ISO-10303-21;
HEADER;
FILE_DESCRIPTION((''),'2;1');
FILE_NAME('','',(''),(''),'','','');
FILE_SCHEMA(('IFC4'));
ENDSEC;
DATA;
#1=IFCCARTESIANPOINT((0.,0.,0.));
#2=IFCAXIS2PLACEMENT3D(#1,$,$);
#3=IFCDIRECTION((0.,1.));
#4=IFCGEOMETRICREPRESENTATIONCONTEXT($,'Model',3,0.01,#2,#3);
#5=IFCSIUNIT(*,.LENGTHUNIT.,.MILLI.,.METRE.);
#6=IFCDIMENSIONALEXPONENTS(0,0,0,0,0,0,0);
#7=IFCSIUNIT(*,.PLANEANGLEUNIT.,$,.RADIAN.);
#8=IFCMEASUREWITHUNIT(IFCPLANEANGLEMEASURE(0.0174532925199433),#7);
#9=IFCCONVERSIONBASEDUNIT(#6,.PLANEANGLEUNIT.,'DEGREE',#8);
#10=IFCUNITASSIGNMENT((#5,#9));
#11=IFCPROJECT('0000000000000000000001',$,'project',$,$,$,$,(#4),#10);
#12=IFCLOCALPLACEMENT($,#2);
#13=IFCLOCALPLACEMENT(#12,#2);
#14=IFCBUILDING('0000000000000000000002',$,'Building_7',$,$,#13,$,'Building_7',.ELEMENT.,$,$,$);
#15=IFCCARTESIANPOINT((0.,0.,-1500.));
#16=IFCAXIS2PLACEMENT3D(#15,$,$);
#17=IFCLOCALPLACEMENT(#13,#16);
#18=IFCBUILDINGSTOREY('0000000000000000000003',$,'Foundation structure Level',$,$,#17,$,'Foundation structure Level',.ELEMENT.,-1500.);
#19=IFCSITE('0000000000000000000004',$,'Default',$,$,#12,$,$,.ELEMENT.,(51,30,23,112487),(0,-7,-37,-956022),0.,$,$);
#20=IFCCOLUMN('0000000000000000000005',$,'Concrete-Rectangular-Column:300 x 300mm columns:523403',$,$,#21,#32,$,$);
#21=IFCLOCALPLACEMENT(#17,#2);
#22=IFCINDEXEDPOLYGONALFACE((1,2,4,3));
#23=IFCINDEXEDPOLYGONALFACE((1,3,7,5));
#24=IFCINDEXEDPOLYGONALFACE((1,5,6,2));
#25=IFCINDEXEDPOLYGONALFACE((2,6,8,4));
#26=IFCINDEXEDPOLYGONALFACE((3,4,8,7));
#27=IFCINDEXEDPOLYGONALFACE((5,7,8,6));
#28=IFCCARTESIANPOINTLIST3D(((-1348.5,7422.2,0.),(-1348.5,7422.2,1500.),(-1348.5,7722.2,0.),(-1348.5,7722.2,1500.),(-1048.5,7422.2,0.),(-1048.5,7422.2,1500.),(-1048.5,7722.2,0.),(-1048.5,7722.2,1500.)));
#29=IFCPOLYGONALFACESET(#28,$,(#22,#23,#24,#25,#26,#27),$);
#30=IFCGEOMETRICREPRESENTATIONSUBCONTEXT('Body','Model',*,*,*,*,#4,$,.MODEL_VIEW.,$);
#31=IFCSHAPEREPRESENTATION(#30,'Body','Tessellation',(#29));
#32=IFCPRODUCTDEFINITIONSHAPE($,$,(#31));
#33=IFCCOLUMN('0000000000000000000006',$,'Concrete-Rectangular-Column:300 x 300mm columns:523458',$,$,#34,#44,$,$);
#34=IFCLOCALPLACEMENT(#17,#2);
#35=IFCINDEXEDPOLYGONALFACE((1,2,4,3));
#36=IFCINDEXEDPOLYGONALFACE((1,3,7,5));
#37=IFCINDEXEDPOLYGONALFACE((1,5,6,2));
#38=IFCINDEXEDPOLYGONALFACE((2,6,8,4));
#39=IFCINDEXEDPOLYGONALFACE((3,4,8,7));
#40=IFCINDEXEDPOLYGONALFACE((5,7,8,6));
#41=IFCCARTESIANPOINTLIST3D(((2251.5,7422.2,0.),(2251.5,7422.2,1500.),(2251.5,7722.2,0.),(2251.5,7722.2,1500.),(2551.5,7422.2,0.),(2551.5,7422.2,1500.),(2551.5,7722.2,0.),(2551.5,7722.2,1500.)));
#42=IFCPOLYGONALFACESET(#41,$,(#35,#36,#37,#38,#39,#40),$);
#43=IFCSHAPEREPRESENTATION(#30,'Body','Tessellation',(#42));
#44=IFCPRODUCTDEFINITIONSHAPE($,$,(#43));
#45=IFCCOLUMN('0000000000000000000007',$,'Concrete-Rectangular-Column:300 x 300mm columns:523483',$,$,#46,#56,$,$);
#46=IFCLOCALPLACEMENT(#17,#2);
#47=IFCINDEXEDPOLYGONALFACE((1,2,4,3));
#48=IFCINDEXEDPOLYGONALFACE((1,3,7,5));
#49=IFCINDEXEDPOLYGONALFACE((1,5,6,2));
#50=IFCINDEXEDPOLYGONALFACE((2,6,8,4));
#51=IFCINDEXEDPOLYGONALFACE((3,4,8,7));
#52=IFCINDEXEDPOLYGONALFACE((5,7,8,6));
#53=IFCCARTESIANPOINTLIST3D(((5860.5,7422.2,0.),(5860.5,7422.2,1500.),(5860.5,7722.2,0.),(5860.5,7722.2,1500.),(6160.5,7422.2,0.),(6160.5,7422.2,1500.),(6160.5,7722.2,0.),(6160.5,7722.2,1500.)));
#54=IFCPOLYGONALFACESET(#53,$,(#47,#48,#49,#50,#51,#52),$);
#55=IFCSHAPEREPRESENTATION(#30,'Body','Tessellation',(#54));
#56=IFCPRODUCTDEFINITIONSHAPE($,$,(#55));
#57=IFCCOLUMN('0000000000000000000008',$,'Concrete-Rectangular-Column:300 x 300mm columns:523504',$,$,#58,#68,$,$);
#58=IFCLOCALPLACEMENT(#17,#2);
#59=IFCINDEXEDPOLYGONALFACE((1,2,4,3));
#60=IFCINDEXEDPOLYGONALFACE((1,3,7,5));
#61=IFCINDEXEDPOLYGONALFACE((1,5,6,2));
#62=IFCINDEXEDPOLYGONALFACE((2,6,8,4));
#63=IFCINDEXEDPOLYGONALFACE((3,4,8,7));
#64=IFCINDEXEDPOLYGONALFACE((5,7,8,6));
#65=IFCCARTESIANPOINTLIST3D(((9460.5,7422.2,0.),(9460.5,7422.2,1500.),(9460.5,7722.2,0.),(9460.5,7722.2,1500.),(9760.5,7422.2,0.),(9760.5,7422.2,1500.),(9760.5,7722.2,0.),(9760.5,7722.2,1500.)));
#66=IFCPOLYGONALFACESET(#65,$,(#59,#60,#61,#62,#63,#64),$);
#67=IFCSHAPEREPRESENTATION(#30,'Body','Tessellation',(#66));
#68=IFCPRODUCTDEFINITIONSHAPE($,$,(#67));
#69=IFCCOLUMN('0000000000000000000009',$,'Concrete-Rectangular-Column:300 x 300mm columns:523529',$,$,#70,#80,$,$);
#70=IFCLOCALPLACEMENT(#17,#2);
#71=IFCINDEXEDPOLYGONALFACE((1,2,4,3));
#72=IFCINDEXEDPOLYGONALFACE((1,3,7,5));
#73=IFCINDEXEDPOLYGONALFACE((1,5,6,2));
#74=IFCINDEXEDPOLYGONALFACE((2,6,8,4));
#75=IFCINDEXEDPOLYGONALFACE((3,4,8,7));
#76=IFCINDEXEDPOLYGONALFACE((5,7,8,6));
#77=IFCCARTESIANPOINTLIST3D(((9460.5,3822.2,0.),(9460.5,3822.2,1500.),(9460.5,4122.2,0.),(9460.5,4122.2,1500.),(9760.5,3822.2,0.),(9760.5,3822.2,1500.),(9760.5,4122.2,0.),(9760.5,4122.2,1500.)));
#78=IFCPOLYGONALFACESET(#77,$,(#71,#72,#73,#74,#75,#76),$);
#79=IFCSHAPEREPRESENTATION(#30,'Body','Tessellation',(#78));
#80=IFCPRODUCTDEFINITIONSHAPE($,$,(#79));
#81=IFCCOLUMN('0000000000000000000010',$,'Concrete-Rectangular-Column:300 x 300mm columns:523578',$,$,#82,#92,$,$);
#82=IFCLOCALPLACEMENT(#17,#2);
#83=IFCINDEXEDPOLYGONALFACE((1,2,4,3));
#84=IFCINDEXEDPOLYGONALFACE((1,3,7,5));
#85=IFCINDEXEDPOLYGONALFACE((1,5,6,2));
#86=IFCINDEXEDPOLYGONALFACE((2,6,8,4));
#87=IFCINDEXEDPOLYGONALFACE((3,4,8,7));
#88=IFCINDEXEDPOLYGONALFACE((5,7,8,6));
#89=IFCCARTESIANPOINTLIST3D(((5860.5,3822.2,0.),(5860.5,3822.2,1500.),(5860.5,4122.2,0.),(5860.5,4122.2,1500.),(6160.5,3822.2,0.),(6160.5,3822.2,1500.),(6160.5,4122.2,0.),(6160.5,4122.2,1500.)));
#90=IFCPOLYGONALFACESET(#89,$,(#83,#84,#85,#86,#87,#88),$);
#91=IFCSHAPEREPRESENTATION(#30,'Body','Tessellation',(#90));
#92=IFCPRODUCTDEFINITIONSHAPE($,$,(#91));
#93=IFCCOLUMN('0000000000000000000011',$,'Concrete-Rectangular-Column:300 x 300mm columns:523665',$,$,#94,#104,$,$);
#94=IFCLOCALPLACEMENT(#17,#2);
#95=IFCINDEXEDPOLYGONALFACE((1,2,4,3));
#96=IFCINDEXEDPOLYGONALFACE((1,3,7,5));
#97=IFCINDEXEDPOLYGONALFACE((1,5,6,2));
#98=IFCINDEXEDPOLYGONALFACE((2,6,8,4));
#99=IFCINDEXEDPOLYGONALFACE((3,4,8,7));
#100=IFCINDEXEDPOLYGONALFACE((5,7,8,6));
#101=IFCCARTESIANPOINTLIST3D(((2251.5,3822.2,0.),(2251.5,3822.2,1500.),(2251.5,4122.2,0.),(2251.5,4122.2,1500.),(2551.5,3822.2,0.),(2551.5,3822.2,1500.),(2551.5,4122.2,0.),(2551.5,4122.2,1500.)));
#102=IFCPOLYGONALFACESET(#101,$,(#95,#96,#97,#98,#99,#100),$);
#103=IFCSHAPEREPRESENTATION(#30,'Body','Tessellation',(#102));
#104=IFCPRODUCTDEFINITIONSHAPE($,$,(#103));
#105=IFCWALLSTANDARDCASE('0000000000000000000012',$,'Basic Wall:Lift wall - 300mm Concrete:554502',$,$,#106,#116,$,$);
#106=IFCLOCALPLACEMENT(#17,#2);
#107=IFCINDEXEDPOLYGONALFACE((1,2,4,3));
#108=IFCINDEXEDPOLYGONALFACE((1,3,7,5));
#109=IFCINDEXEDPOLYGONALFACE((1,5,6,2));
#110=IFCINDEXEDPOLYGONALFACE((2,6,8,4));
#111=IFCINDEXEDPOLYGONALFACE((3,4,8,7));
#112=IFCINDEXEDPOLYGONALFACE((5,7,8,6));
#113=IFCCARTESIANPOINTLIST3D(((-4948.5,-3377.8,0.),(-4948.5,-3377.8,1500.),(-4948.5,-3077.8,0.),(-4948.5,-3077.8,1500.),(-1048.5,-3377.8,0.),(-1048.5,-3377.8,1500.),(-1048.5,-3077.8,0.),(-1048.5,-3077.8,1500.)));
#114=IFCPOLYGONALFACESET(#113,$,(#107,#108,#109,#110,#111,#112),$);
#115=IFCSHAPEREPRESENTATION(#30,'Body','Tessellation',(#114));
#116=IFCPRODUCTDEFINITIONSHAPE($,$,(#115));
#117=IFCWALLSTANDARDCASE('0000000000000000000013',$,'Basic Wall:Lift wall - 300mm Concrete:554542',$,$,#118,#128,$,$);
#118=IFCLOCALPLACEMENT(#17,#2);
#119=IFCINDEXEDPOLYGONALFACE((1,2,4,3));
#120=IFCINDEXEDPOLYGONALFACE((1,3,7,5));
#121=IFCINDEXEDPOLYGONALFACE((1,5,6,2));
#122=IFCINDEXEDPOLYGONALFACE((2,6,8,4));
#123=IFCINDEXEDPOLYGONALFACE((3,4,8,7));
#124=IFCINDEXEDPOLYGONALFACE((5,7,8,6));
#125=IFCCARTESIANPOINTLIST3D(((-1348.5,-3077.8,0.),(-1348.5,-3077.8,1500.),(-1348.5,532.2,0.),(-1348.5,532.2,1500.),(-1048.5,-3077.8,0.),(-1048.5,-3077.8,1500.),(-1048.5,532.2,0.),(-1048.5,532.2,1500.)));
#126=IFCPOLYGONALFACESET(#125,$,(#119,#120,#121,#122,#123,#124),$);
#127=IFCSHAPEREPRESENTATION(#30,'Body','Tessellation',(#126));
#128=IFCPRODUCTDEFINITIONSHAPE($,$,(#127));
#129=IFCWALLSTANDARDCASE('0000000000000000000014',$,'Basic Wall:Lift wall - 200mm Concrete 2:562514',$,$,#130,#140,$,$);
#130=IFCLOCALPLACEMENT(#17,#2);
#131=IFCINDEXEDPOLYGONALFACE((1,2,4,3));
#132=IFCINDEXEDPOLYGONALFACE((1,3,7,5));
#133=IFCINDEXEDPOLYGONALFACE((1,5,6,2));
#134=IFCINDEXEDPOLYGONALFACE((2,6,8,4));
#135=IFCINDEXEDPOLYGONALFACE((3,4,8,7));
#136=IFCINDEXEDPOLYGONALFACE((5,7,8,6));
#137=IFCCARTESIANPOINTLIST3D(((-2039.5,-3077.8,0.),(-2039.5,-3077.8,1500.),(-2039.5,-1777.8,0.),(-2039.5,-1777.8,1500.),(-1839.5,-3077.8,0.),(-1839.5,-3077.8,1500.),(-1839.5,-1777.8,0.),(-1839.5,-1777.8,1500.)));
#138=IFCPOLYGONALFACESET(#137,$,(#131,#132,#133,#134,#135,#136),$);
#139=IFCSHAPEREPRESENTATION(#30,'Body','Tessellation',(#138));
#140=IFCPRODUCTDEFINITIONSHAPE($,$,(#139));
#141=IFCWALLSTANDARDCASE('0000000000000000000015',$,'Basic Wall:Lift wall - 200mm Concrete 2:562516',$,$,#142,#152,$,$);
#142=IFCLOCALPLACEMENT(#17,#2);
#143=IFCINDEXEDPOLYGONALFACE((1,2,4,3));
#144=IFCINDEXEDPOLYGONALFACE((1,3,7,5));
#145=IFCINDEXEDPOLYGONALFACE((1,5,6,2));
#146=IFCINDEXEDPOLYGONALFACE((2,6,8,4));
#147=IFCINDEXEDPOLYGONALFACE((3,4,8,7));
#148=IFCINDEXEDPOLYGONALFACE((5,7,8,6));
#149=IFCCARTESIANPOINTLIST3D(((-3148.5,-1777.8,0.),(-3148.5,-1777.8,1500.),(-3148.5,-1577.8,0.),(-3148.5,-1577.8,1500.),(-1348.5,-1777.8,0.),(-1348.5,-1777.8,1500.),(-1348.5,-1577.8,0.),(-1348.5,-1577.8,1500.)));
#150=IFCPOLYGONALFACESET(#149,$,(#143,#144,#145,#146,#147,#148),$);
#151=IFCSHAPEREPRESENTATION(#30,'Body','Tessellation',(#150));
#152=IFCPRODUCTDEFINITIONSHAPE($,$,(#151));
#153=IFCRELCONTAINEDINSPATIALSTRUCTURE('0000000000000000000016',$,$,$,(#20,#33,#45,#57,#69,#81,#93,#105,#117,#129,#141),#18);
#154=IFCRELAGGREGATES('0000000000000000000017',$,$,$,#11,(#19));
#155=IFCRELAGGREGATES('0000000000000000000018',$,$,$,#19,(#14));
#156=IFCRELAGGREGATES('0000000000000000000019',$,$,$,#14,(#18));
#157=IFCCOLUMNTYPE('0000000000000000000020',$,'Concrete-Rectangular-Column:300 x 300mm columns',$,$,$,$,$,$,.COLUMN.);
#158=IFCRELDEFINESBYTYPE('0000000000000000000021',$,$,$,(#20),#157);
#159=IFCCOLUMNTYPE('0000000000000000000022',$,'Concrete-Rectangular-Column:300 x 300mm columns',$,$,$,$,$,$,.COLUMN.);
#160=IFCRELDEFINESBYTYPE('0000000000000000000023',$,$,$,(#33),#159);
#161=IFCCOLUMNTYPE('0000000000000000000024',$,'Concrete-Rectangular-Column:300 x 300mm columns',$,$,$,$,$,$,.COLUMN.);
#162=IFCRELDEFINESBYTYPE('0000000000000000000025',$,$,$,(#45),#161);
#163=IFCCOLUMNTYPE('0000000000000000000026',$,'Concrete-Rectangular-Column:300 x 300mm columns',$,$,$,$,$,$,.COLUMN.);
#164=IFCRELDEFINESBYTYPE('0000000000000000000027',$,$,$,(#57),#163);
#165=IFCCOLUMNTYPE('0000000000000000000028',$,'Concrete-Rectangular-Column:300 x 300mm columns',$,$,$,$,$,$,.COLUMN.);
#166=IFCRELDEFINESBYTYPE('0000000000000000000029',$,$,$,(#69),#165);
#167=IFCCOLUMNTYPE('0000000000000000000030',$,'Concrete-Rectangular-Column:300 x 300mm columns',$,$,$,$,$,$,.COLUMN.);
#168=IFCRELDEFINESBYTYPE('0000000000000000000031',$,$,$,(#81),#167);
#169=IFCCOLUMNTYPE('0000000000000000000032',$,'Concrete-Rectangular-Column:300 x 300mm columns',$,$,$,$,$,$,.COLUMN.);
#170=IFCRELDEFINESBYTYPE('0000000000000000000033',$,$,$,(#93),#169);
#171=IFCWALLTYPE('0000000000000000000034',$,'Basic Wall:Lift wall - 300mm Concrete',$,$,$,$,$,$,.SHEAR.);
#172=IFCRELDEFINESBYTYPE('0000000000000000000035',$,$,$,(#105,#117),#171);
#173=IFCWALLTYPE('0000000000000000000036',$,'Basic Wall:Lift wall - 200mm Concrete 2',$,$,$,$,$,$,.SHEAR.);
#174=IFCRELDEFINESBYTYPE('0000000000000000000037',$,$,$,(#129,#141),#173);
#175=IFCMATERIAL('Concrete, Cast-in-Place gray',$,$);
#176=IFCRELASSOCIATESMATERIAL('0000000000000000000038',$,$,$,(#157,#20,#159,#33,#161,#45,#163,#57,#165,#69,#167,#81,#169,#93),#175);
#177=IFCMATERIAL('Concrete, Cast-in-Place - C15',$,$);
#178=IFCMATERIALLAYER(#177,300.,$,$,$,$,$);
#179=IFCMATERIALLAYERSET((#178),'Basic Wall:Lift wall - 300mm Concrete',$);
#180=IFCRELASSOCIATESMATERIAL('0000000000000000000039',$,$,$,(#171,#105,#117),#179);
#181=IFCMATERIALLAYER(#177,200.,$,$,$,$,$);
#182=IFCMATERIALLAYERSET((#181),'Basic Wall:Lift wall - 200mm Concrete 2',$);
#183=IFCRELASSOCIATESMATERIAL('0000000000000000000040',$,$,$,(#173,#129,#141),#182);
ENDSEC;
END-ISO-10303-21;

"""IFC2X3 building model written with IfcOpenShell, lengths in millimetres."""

from ifc_helpers import new_model, entity, si_unit, converted_unit, direction, frame, frame_2d, origin, place, context, subcontext, project, spatial, rectangle, extrude, source, transform, mapped, material, layer, layer_set, layer_usage, type_object, type_shapes, element, save


model = new_model("IFC2X3")

# Units and contexts
model_context = context("Model", 3, precision=0.01, world=origin(), true_north=direction((0.0, 1.0)))
body_context = subcontext(model_context, "Body", "Model", "MODEL_VIEW")
ifc_project = project(units=[si_unit("LENGTHUNIT", "METRE", prefix="MILLI"), converted_unit("PLANEANGLEUNIT", "DEGREE", entity("IfcPlaneAngleMeasure", 0.0174532925199433), si_unit("PLANEANGLEUNIT", "RADIAN"), dimensions=[0, 0, 0, 0, 0, 0, 0])], contexts=[model_context])

# Site, building, storey
site_placement = place(None, origin())
site = spatial("IfcSite", under=ifc_project, at=site_placement, Name="Default", CompositionType="ELEMENT", RefLatitude=(51, 30, 23, 112487), RefLongitude=(0, -7, -37, -956022), RefElevation=0.0)
building_placement = place(site_placement, origin())
building = spatial("IfcBuilding", under=site, at=building_placement, Name="Building_7", LongName="Building_7", CompositionType="ELEMENT")
storey_placement = place(building_placement, frame((0.0, 0.0, -1500.0)))
storey = spatial("IfcBuildingStorey", under=building, at=storey_placement, Name="Foundation structure Level", LongName="Foundation structure Level", CompositionType="ELEMENT", Elevation=-1500.0)

# Columns
ifc_material_1 = material(Name="Concrete, Cast-in-Place gray")
column_type_1 = type_object("IfcColumnType", Name="Concrete-Rectangular-Column:300 x 300mm columns", PredefinedType="COLUMN", material=ifc_material_1)
shared_shape_1 = source(origin(), body_context, "Body", "SweptSolid", [
    extrude(rectangle(XDim=300.0, YDim=300.0, at=frame_2d((0.0, 0.0), x_axis=(1.0, 0.0))), frame((-1198.5, 7572.2, -1500.0), z_axis=(0.0, 0.0, 1.0), x_axis=(-1.0, 0.0, 0.0)), (0.0, 0.0, 1.0), 1500.0),
])
type_shapes(column_type_1, [shared_shape_1])
column_1_placement = place(storey_placement, frame((0.0, 0.0, 1500.0)))
element("IfcColumn", 1, at=column_1_placement, inside=storey, type_object=column_type_1, material=ifc_material_1, Name="Concrete-Rectangular-Column:300 x 300mm columns:523403", context=body_context, shape_type="MappedRepresentation", body=[
    mapped(shared_shape_1, transform((0.0, 0.0, 0.0), scale=1.0)),
])
column_type_2 = type_object("IfcColumnType", Name="Concrete-Rectangular-Column:300 x 300mm columns", PredefinedType="COLUMN", material=ifc_material_1)
shared_shape_2 = source(origin(), body_context, "Body", "SweptSolid", [
    extrude(rectangle(XDim=300.0, YDim=300.0, at=frame_2d((0.0, 0.0), x_axis=(1.0, 0.0))), frame((2401.5, 7572.2, -1500.0), z_axis=(0.0, 0.0, 1.0), x_axis=(-1.0, 0.0, 0.0)), (0.0, 0.0, 1.0), 1500.0),
])
type_shapes(column_type_2, [shared_shape_2])
column_2_placement = place(storey_placement, frame((0.0, 0.0, 1500.0)))
element("IfcColumn", 2, at=column_2_placement, inside=storey, type_object=column_type_2, material=ifc_material_1, Name="Concrete-Rectangular-Column:300 x 300mm columns:523458", context=body_context, shape_type="MappedRepresentation", body=[
    mapped(shared_shape_2, transform((0.0, 0.0, 0.0), scale=1.0)),
])
column_type_3 = type_object("IfcColumnType", Name="Concrete-Rectangular-Column:300 x 300mm columns", PredefinedType="COLUMN", material=ifc_material_1)
shared_shape_3 = source(origin(), body_context, "Body", "SweptSolid", [
    extrude(rectangle(XDim=300.0, YDim=300.0, at=frame_2d((0.0, 0.0), x_axis=(1.0, 0.0))), frame((6010.5, 7572.2, -1500.0), z_axis=(0.0, 0.0, 1.0), x_axis=(-1.0, 0.0, 0.0)), (0.0, 0.0, 1.0), 1500.0),
])
type_shapes(column_type_3, [shared_shape_3])
column_3_placement = place(storey_placement, frame((0.0, 0.0, 1500.0)))
element("IfcColumn", 3, at=column_3_placement, inside=storey, type_object=column_type_3, material=ifc_material_1, Name="Concrete-Rectangular-Column:300 x 300mm columns:523483", context=body_context, shape_type="MappedRepresentation", body=[
    mapped(shared_shape_3, transform((0.0, 0.0, 0.0), scale=1.0)),
])
column_type_4 = type_object("IfcColumnType", Name="Concrete-Rectangular-Column:300 x 300mm columns", PredefinedType="COLUMN", material=ifc_material_1)
shared_shape_4 = source(origin(), body_context, "Body", "SweptSolid", [
    extrude(rectangle(XDim=300.0, YDim=300.0, at=frame_2d((0.0, 0.0), x_axis=(1.0, 0.0))), frame((9610.5, 7572.2, -1500.0), z_axis=(0.0, 0.0, 1.0), x_axis=(-1.0, 0.0, 0.0)), (0.0, 0.0, 1.0), 1500.0),
])
type_shapes(column_type_4, [shared_shape_4])
column_4_placement = place(storey_placement, frame((0.0, 0.0, 1500.0)))
element("IfcColumn", 4, at=column_4_placement, inside=storey, type_object=column_type_4, material=ifc_material_1, Name="Concrete-Rectangular-Column:300 x 300mm columns:523504", context=body_context, shape_type="MappedRepresentation", body=[
    mapped(shared_shape_4, transform((0.0, 0.0, 0.0), scale=1.0)),
])
column_type_5 = type_object("IfcColumnType", Name="Concrete-Rectangular-Column:300 x 300mm columns", PredefinedType="COLUMN", material=ifc_material_1)
shared_shape_5 = source(origin(), body_context, "Body", "SweptSolid", [
    extrude(rectangle(XDim=300.0, YDim=300.0, at=frame_2d((0.0, 0.0), x_axis=(1.0, 0.0))), frame((9610.5, 3972.2, -1500.0), z_axis=(0.0, 0.0, 1.0), x_axis=(-1.0, 0.0, 0.0)), (0.0, 0.0, 1.0), 1500.0),
])
type_shapes(column_type_5, [shared_shape_5])
column_5_placement = place(storey_placement, frame((0.0, 0.0, 1500.0)))
element("IfcColumn", 5, at=column_5_placement, inside=storey, type_object=column_type_5, material=ifc_material_1, Name="Concrete-Rectangular-Column:300 x 300mm columns:523529", context=body_context, shape_type="MappedRepresentation", body=[
    mapped(shared_shape_5, transform((0.0, 0.0, 0.0), scale=1.0)),
])
column_type_6 = type_object("IfcColumnType", Name="Concrete-Rectangular-Column:300 x 300mm columns", PredefinedType="COLUMN", material=ifc_material_1)
shared_shape_6 = source(origin(), body_context, "Body", "SweptSolid", [
    extrude(rectangle(XDim=300.0, YDim=300.0, at=frame_2d((0.0, 0.0), x_axis=(1.0, 0.0))), frame((6010.5, 3972.2, -1500.0), z_axis=(0.0, 0.0, 1.0), x_axis=(-1.0, 0.0, 0.0)), (0.0, 0.0, 1.0), 1500.0),
])
type_shapes(column_type_6, [shared_shape_6])
column_6_placement = place(storey_placement, frame((0.0, 0.0, 1500.0)))
element("IfcColumn", 6, at=column_6_placement, inside=storey, type_object=column_type_6, material=ifc_material_1, Name="Concrete-Rectangular-Column:300 x 300mm columns:523578", context=body_context, shape_type="MappedRepresentation", body=[
    mapped(shared_shape_6, transform((0.0, 0.0, 0.0), scale=1.0)),
])
column_type_7 = type_object("IfcColumnType", Name="Concrete-Rectangular-Column:300 x 300mm columns", PredefinedType="COLUMN", material=ifc_material_1)
shared_shape_7 = source(origin(), body_context, "Body", "SweptSolid", [
    extrude(rectangle(XDim=300.0, YDim=300.0, at=frame_2d((0.0, 0.0), x_axis=(1.0, 0.0))), frame((2401.5, 3972.2, -1500.0), z_axis=(0.0, 0.0, 1.0), x_axis=(-1.0, 0.0, 0.0)), (0.0, 0.0, 1.0), 1500.0),
])
type_shapes(column_type_7, [shared_shape_7])
column_7_placement = place(storey_placement, frame((0.0, 0.0, 1500.0)))
element("IfcColumn", 7, at=column_7_placement, inside=storey, type_object=column_type_7, material=ifc_material_1, Name="Concrete-Rectangular-Column:300 x 300mm columns:523665", context=body_context, shape_type="MappedRepresentation", body=[
    mapped(shared_shape_7, transform((0.0, 0.0, 0.0), scale=1.0)),
])

# Walls
ifc_material_2 = material(Name="Concrete, Cast-in-Place - C15")
ifc_layer_1 = layer(ifc_material_2, 300.0)
ifc_layer_set_1 = layer_set([ifc_layer_1], Name="Basic Wall:Lift wall - 300mm Concrete")
ifc_layer_usage_1 = layer_usage(ifc_layer_set_1, "AXIS2", "NEGATIVE", 150.0)
wall_type_1 = type_object("IfcWallType", Name="Basic Wall:Lift wall - 300mm Concrete", PredefinedType="SHEAR", material=ifc_layer_set_1)
wall_1_placement = place(storey_placement, frame((-4948.5, -3227.8, 0.0)))
element("IfcWallStandardCase", 8, at=wall_1_placement, inside=storey, type_object=wall_type_1, material=ifc_layer_usage_1, Name="Basic Wall:Lift wall - 300mm Concrete:554502", context=body_context, shape_type="SweptSolid", body=[
    extrude(rectangle(XDim=3900.0, YDim=300.0, at=frame_2d((1950.0, 0.0), x_axis=(-1.0, 0.0))), origin(), (0.0, 0.0, 1.0), 1500.0),
])
ifc_layer_usage_2 = layer_usage(ifc_layer_set_1, "AXIS2", "NEGATIVE", 150.0)
wall_2_placement = place(storey_placement, frame((-1198.5, -3077.8, 0.0), z_axis=(0.0, 0.0, 1.0), x_axis=(0.0, 1.0, 0.0)))
element("IfcWallStandardCase", 9, at=wall_2_placement, inside=storey, type_object=wall_type_1, material=ifc_layer_usage_2, Name="Basic Wall:Lift wall - 300mm Concrete:554542", context=body_context, shape_type="SweptSolid", body=[
    extrude(rectangle(XDim=3610.0, YDim=300.0, at=frame_2d((1805.0, 0.0), x_axis=(-1.0, 0.0))), origin(), (0.0, 0.0, 1.0), 1500.0),
])
ifc_layer_2 = layer(ifc_material_2, 200.0)
ifc_layer_set_2 = layer_set([ifc_layer_2], Name="Basic Wall:Lift wall - 200mm Concrete 2")
ifc_layer_usage_3 = layer_usage(ifc_layer_set_2, "AXIS2", "NEGATIVE", 100.0)
wall_type_2 = type_object("IfcWallType", Name="Basic Wall:Lift wall - 200mm Concrete 2", PredefinedType="SHEAR", material=ifc_layer_set_2)
wall_3_placement = place(storey_placement, frame((-1939.5, -3077.8, 0.0), z_axis=(0.0, 0.0, 1.0), x_axis=(0.0, 1.0, 0.0)))
element("IfcWallStandardCase", 10, at=wall_3_placement, inside=storey, type_object=wall_type_2, material=ifc_layer_usage_3, Name="Basic Wall:Lift wall - 200mm Concrete 2:562514", context=body_context, shape_type="SweptSolid", body=[
    extrude(rectangle(XDim=1300.0, YDim=200.0, at=frame_2d((650.0, 0.0), x_axis=(-1.0, 0.0))), origin(), (0.0, 0.0, 1.0), 1500.0),
])
ifc_layer_usage_4 = layer_usage(ifc_layer_set_2, "AXIS2", "NEGATIVE", 100.0)
wall_4_placement = place(storey_placement, frame((-1348.5, -1677.8, 0.0), z_axis=(0.0, 0.0, 1.0), x_axis=(-1.0, 0.0, 0.0)))
element("IfcWallStandardCase", 11, at=wall_4_placement, inside=storey, type_object=wall_type_2, material=ifc_layer_usage_4, Name="Basic Wall:Lift wall - 200mm Concrete 2:562516", context=body_context, shape_type="SweptSolid", body=[
    extrude(rectangle(XDim=1800.0, YDim=200.0, at=frame_2d((900.0, 0.0), x_axis=(-1.0, 0.0))), origin(), (0.0, 0.0, 1.0), 1500.0),
])

save(model, "model.ifc")
